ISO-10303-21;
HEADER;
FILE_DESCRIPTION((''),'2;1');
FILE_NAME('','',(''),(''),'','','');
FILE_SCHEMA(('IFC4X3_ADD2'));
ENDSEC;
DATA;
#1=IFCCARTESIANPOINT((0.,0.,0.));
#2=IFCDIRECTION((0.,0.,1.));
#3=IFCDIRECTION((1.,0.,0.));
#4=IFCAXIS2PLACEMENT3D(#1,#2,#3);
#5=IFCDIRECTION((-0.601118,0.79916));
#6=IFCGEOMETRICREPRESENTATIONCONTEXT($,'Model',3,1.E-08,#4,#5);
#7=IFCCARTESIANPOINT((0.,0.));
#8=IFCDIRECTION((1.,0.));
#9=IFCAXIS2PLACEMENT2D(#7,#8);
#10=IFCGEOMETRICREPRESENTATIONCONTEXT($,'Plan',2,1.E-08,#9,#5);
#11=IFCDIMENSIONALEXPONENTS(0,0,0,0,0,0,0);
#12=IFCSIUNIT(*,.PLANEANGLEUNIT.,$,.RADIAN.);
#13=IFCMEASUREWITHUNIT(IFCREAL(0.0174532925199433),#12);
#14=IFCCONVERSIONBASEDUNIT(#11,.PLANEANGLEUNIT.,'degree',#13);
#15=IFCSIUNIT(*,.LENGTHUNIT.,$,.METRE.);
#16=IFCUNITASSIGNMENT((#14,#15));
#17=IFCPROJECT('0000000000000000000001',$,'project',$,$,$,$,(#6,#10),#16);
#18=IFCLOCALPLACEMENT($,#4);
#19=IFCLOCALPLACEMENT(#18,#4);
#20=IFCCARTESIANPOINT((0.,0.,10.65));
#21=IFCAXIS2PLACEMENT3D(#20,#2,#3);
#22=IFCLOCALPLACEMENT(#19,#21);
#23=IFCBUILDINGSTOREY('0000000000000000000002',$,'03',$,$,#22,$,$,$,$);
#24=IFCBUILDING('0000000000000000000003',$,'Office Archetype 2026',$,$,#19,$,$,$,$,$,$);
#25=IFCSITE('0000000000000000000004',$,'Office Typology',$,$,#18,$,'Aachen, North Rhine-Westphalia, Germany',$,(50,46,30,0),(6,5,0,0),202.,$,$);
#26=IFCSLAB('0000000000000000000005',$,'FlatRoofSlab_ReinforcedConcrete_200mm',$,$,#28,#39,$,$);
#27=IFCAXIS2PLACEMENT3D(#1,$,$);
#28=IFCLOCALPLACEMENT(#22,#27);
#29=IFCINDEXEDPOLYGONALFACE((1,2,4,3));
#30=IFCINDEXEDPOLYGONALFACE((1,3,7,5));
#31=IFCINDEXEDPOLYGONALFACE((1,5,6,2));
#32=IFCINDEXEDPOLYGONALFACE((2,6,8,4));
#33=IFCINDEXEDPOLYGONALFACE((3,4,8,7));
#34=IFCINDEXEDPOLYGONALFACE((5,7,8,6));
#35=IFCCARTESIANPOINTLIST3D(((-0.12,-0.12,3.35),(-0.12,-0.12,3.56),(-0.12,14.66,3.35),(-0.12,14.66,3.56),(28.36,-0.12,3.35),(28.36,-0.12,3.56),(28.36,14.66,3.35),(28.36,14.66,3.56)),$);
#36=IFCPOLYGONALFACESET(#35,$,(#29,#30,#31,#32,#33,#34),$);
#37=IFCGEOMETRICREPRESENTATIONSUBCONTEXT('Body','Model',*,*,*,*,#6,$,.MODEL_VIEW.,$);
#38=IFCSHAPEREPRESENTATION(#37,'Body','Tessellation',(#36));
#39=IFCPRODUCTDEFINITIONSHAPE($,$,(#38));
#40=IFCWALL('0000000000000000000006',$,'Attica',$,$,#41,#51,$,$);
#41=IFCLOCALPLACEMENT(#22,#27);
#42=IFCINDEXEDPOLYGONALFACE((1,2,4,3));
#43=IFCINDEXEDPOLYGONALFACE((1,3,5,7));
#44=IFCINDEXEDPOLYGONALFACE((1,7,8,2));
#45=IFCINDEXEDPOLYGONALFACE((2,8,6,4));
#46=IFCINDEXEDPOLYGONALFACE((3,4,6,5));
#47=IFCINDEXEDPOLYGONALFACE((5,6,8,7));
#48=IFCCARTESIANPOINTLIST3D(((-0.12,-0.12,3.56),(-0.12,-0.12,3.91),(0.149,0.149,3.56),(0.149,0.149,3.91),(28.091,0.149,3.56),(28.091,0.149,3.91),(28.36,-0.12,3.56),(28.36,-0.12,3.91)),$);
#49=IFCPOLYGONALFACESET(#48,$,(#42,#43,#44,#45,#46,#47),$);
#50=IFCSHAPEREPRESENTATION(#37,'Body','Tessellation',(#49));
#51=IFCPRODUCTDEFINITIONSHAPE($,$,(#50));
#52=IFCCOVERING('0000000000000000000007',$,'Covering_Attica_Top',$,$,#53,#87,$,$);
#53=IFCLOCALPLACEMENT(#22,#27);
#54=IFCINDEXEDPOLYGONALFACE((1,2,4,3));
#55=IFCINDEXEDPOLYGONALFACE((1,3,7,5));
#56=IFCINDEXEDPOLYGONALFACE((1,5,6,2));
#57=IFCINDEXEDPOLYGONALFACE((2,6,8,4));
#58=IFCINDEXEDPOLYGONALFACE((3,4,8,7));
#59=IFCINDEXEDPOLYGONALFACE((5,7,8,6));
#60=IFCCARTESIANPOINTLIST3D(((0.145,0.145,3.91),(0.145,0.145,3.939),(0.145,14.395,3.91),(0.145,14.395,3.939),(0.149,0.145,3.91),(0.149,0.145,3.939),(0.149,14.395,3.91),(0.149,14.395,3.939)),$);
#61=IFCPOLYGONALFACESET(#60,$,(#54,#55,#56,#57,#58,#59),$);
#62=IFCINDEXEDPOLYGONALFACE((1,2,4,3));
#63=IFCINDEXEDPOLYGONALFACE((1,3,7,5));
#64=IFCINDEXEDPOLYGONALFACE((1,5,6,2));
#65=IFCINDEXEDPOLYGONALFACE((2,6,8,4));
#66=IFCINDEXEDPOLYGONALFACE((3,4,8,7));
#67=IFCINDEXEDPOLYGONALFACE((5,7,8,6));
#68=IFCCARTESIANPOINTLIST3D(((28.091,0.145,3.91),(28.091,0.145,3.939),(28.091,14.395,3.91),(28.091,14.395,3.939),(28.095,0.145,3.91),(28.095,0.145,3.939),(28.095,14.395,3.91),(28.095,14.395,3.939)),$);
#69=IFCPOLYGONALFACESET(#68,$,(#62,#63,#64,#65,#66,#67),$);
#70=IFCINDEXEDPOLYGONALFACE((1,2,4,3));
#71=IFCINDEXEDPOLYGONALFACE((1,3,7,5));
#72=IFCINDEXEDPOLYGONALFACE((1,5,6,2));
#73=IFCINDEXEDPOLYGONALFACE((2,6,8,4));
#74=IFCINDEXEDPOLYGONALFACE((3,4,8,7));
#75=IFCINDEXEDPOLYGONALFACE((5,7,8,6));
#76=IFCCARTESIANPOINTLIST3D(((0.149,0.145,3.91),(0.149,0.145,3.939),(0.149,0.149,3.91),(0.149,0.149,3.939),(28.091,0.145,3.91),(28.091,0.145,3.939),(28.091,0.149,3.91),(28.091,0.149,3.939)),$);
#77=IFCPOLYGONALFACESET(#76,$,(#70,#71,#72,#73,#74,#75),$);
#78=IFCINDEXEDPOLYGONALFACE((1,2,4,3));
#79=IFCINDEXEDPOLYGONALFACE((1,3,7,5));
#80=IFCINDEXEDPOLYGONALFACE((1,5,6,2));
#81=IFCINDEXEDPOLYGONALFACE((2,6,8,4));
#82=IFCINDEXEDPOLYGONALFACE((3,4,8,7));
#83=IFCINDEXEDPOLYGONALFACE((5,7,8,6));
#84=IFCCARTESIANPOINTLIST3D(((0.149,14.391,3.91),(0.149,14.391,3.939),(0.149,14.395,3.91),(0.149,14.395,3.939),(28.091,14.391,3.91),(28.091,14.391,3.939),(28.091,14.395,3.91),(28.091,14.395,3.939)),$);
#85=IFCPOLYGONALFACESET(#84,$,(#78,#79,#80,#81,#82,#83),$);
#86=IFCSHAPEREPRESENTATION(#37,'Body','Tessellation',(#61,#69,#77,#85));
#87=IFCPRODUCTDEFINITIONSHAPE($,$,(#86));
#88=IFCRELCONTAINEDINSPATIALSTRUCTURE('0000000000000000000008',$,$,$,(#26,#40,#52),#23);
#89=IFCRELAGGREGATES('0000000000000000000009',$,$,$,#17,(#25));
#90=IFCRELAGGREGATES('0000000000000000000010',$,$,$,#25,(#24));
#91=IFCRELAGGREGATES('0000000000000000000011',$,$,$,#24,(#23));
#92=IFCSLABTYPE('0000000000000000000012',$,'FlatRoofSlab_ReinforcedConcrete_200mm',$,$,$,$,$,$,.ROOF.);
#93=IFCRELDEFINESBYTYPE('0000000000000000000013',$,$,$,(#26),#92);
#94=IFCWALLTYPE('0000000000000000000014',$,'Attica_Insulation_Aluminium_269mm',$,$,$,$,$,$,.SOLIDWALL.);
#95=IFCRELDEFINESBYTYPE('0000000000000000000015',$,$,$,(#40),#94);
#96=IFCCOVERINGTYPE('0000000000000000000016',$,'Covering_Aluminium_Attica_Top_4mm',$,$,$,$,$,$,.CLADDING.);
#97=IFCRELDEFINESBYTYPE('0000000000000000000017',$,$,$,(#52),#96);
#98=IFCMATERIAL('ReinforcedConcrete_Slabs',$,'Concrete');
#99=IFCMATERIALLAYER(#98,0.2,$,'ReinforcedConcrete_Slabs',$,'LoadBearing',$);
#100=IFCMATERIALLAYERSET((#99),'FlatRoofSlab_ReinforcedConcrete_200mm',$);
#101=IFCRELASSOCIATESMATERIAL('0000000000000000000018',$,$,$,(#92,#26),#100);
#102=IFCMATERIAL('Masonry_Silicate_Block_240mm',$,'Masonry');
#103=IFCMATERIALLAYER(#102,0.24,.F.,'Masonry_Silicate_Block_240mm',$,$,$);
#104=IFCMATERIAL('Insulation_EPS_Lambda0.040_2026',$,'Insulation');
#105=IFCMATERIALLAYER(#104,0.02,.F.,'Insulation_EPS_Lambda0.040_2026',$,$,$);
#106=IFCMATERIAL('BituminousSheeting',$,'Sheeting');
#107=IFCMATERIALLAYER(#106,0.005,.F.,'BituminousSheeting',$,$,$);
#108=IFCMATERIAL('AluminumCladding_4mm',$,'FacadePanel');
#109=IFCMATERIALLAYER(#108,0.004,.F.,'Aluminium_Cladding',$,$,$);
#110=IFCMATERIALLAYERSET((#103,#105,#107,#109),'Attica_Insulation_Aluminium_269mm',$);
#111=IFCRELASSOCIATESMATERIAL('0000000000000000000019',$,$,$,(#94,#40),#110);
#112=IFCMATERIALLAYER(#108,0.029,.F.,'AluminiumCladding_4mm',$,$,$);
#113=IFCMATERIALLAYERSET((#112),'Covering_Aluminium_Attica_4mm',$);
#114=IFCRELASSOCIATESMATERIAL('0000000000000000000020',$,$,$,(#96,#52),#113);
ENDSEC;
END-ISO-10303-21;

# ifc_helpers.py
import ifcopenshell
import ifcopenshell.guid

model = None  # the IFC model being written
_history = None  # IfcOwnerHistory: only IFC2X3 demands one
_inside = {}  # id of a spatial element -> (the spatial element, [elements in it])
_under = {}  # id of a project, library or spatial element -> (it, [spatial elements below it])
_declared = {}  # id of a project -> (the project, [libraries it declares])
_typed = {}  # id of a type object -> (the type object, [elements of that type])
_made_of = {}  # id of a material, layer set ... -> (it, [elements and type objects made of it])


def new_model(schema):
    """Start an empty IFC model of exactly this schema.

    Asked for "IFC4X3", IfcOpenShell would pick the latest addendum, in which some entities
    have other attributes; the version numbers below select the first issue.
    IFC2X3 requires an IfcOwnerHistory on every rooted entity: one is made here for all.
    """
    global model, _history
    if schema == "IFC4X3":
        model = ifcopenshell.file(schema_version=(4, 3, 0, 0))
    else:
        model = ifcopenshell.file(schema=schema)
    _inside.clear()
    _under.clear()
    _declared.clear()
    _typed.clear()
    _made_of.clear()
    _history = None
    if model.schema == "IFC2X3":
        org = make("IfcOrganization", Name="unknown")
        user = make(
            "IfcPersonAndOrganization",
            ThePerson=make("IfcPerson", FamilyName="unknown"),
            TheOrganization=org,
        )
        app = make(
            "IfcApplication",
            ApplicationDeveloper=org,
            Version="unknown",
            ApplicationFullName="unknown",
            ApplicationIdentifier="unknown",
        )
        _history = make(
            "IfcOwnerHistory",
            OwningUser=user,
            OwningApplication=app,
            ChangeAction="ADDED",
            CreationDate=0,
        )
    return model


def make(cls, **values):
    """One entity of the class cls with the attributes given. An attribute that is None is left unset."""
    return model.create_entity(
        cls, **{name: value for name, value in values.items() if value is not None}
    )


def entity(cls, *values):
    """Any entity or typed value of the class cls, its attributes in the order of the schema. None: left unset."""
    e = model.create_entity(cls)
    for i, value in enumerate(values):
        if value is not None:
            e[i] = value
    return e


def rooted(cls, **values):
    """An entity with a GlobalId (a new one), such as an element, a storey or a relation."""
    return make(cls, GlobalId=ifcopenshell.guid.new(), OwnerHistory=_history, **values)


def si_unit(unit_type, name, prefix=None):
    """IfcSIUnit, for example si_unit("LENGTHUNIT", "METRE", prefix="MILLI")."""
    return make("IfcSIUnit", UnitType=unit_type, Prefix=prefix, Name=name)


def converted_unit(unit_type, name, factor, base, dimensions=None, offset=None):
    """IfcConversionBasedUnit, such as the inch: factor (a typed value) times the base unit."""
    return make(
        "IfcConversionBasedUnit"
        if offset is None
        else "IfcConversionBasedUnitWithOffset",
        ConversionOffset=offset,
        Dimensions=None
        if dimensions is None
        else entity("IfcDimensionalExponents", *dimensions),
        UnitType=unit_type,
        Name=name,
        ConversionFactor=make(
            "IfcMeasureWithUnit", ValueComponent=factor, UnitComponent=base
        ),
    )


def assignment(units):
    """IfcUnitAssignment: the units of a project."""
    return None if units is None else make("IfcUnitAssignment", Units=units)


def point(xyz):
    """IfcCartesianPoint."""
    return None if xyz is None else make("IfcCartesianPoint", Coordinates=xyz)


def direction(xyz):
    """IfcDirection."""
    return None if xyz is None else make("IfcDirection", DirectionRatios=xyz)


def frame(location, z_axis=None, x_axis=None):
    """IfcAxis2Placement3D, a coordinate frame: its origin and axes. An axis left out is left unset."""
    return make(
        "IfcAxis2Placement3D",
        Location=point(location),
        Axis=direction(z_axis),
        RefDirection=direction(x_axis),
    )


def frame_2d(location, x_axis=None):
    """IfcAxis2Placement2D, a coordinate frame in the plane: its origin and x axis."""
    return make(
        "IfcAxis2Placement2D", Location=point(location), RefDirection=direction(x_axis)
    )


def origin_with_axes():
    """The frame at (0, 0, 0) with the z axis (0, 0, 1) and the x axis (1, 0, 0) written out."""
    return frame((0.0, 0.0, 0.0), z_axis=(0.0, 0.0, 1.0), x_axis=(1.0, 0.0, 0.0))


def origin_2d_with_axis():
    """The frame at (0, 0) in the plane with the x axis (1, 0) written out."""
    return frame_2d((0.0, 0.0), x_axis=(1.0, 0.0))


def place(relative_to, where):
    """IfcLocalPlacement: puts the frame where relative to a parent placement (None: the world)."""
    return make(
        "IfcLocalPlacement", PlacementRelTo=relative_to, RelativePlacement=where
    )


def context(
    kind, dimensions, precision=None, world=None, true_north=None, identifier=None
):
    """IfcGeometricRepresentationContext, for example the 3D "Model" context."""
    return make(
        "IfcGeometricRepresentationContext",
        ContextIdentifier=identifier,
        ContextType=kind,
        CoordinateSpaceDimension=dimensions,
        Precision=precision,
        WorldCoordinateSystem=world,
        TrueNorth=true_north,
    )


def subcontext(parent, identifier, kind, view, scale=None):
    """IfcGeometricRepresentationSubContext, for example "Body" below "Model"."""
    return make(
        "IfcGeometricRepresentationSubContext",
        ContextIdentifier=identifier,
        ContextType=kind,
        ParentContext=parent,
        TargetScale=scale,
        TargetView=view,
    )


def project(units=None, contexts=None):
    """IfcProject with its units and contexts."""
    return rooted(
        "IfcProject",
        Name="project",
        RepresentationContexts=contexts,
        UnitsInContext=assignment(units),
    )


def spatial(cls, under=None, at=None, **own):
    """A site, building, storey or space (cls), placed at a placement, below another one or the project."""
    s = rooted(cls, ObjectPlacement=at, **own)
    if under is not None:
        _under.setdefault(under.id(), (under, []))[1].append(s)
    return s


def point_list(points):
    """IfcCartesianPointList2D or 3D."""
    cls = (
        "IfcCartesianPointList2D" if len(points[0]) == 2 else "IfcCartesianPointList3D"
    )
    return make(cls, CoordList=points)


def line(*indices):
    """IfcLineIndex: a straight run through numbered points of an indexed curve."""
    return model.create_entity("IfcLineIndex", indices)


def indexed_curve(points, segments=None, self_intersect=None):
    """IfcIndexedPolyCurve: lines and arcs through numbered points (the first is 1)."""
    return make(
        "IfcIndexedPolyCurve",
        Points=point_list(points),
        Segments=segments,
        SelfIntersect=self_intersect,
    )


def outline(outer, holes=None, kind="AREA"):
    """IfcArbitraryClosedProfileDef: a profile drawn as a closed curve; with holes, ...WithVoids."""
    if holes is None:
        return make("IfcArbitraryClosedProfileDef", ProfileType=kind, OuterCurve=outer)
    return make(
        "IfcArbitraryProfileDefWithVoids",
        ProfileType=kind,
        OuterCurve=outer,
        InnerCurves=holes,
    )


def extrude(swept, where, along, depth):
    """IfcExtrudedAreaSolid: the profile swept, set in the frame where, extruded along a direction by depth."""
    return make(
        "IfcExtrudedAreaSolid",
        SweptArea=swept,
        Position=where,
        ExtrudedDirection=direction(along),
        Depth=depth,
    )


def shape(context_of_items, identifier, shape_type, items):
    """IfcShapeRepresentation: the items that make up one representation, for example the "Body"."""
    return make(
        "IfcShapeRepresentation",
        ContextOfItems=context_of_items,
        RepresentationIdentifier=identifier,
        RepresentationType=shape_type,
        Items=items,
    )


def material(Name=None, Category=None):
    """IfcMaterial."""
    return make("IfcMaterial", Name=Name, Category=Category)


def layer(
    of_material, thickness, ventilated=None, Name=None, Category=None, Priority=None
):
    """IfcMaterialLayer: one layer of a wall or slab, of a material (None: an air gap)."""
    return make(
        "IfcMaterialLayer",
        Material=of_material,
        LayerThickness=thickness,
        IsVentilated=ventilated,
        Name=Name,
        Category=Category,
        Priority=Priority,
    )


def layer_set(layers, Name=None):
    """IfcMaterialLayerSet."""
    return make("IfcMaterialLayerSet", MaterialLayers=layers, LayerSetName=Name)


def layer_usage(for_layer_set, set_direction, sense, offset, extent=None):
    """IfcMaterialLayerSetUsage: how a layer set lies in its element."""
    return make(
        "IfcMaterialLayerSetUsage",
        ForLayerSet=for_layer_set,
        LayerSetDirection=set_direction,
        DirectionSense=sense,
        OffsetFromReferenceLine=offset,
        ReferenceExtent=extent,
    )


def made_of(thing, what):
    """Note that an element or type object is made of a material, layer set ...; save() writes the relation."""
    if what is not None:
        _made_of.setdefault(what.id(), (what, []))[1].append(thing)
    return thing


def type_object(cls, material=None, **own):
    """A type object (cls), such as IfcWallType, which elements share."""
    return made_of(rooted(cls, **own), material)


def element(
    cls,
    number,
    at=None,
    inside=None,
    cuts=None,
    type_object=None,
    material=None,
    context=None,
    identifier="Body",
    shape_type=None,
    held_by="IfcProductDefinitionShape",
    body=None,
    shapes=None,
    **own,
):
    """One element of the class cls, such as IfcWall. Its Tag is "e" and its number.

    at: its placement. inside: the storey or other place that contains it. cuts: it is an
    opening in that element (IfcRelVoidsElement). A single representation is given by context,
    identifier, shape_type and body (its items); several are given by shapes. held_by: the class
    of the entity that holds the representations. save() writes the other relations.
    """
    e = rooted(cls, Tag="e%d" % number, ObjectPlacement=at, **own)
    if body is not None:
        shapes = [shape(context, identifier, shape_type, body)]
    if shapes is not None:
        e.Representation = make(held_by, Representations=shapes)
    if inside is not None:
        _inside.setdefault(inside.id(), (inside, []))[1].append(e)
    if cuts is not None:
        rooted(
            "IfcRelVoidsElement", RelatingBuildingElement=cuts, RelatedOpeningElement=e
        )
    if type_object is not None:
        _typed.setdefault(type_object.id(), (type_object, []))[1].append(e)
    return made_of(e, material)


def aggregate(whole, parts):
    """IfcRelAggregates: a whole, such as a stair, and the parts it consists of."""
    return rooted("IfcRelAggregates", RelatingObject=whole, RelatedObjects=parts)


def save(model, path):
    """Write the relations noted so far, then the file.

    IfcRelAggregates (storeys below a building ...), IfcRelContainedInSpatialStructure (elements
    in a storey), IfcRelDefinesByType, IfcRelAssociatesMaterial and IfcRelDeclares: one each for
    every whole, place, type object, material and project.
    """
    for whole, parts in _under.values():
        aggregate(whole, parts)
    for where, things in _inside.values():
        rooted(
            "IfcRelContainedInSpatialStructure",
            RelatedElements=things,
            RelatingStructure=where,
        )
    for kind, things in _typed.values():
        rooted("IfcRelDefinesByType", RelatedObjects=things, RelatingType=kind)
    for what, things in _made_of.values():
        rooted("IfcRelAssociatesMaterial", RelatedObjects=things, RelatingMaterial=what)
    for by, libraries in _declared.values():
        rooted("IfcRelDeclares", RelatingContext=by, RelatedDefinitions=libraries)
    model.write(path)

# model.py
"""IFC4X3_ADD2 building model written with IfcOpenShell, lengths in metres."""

from ifc_helpers import new_model, entity, si_unit, converted_unit, direction, frame, origin_with_axes, origin_2d_with_axis, place, context, subcontext, project, spatial, line, indexed_curve, outline, extrude, material, layer, layer_set, layer_usage, type_object, element, save


model = new_model("IFC4X3_ADD2")

# Units and contexts
model_context = context("Model", 3, precision=1e-08, world=origin_with_axes(), true_north=direction((-0.601118, 0.79916)))
plan_context = context("Plan", 2, precision=1e-08, world=origin_2d_with_axis(), true_north=direction((-0.601118, 0.79916)))
body_context = subcontext(model_context, "Body", "Model", "MODEL_VIEW")
ifc_project = project(units=[converted_unit("PLANEANGLEUNIT", "degree", entity("IfcReal", 0.0174532925199433), si_unit("PLANEANGLEUNIT", "RADIAN"), dimensions=[0, 0, 0, 0, 0, 0, 0]), si_unit("LENGTHUNIT", "METRE")], contexts=[model_context, plan_context])

# Site, building, storey
site_placement = place(None, origin_with_axes())
site = spatial("IfcSite", under=ifc_project, at=site_placement, Name="Office Typology", LongName="Aachen, North Rhine-Westphalia, Germany", RefLatitude=(50, 46, 30, 0), RefLongitude=(6, 5, 0, 0), RefElevation=202.0)
building_placement = place(site_placement, origin_with_axes())
building = spatial("IfcBuilding", under=site, at=building_placement, Name="Office Archetype 2026")
storey_placement = place(building_placement, frame((0.0, 0.0, 10.65), z_axis=(0.0, 0.0, 1.0), x_axis=(1.0, 0.0, 0.0)))
storey = spatial("IfcBuildingStorey", under=building, at=storey_placement, Name="03")

# Slab
ifc_material_1 = material(Name="ReinforcedConcrete_Slabs", Category="Concrete")
ifc_layer_1 = layer(ifc_material_1, 0.2, Name="ReinforcedConcrete_Slabs", Category="LoadBearing")
ifc_layer_set_1 = layer_set([ifc_layer_1], Name="FlatRoofSlab_ReinforcedConcrete_200mm")
ifc_layer_usage_1 = layer_usage(ifc_layer_set_1, "AXIS3", "POSITIVE", 0.0)
slab_type = type_object("IfcSlabType", Name="FlatRoofSlab_ReinforcedConcrete_200mm", PredefinedType="ROOF", material=ifc_layer_set_1)
slab_placement = place(storey_placement, frame((-0.12, -0.12, 3.35), z_axis=(0.0, 0.0, 1.0), x_axis=(1.0, 0.0, 0.0)))
element("IfcSlab", 1, at=slab_placement, inside=storey, type_object=slab_type, material=ifc_layer_usage_1, Name="FlatRoofSlab_ReinforcedConcrete_200mm", context=body_context, shape_type="SweptSolid", body=[
    extrude(outline(indexed_curve([(0.0, 0.0), (28.48, 0.0), (28.48, 14.78), (0.0, 14.78), (0.0, 0.0)])), None, (0.0, 0.0, 1.0), 0.21),
])

# Wall
ifc_material_2 = material(Name="Masonry_Silicate_Block_240mm", Category="Masonry")
ifc_layer_2 = layer(ifc_material_2, 0.24, ventilated=False, Name="Masonry_Silicate_Block_240mm")
ifc_material_3 = material(Name="Insulation_EPS_Lambda0.040_2026", Category="Insulation")
ifc_layer_3 = layer(ifc_material_3, 0.02, ventilated=False, Name="Insulation_EPS_Lambda0.040_2026")
ifc_material_4 = material(Name="BituminousSheeting", Category="Sheeting")
ifc_layer_4 = layer(ifc_material_4, 0.005, ventilated=False, Name="BituminousSheeting")
ifc_material_5 = material(Name="AluminumCladding_4mm", Category="FacadePanel")
ifc_layer_5 = layer(ifc_material_5, 0.004, ventilated=False, Name="Aluminium_Cladding")
ifc_layer_set_2 = layer_set([ifc_layer_2, ifc_layer_3, ifc_layer_4, ifc_layer_5], Name="Attica_Insulation_Aluminium_269mm")
ifc_layer_usage_2 = layer_usage(ifc_layer_set_2, "AXIS2", "POSITIVE", 0.0)
wall_type = type_object("IfcWallType", Name="Attica_Insulation_Aluminium_269mm", PredefinedType="SOLIDWALL", material=ifc_layer_set_2)
wall_placement = place(storey_placement, frame((-0.12, -0.12, 3.56), z_axis=(0.0, 0.0, 1.0), x_axis=(1.0, 0.0, 0.0)))
element("IfcWall", 2, at=wall_placement, inside=storey, type_object=wall_type, material=ifc_layer_usage_2, Name="Attica", context=body_context, shape_type="SweptSolid", body=[
    extrude(outline(indexed_curve([(0.0, 0.0), (0.269, 0.269), (28.211, 0.269), (28.48, 0.0)], segments=[line(1, 2, 3, 4, 1)])), origin_with_axes(), (0.0, 0.0, 1.0), 0.35),
])

# Covering
ifc_layer_6 = layer(ifc_material_5, 0.029, ventilated=False, Name="AluminiumCladding_4mm")
ifc_layer_set_3 = layer_set([ifc_layer_6], Name="Covering_Aluminium_Attica_4mm")
ifc_layer_usage_3 = layer_usage(ifc_layer_set_3, "AXIS3", "POSITIVE", 0.0)
covering_type_1 = type_object("IfcCoveringType", Name="Covering_Aluminium_Attica_Top_4mm", PredefinedType="CLADDING", material=ifc_layer_set_3)
covering_1_placement = place(storey_placement, frame((0.0, 0.0, 3.91), z_axis=(0.0, 0.0, 1.0), x_axis=(1.0, 0.0, 0.0)))
element("IfcCovering", 3, at=covering_1_placement, inside=storey, type_object=covering_type_1, material=ifc_layer_usage_3, Name="Covering_Attica_Top", context=body_context, shape_type="SweptSolid", body=[
    extrude(outline(indexed_curve([(0.145, 0.145), (0.149, 0.145), (0.149, 14.395), (0.145, 14.395), (0.145, 0.145)])), origin_with_axes(), (0.0, 0.0, 1.0), 0.029),
    extrude(outline(indexed_curve([(0.145, 0.145), (0.149, 0.145), (0.149, 14.395), (0.145, 14.395), (0.145, 0.145)])), frame((27.946, 0.0, 0.0), z_axis=(0.0, 0.0, 1.0), x_axis=(1.0, 0.0, 0.0)), (0.0, 0.0, 1.0), 0.029),
    extrude(outline(indexed_curve([(0.145, 27.797), (0.149, 27.797), (0.149, -0.145), (0.145, -0.145), (0.145, 27.797)])), frame((27.946, 0.0, 0.0), z_axis=(0.0, 0.0, 1.0), x_axis=(0.0, 1.0, 0.0)), (0.0, 0.0, 1.0), 0.029),
    extrude(outline(indexed_curve([(0.145, 27.797), (0.149, 27.797), (0.149, -0.145), (0.145, -0.145), (0.145, 27.797)])), frame((27.946, 14.246, 0.0), z_axis=(0.0, 0.0, 1.0), x_axis=(0.0, 1.0, 0.0)), (0.0, 0.0, 1.0), 0.029),
])

save(model, "model.ifc")
